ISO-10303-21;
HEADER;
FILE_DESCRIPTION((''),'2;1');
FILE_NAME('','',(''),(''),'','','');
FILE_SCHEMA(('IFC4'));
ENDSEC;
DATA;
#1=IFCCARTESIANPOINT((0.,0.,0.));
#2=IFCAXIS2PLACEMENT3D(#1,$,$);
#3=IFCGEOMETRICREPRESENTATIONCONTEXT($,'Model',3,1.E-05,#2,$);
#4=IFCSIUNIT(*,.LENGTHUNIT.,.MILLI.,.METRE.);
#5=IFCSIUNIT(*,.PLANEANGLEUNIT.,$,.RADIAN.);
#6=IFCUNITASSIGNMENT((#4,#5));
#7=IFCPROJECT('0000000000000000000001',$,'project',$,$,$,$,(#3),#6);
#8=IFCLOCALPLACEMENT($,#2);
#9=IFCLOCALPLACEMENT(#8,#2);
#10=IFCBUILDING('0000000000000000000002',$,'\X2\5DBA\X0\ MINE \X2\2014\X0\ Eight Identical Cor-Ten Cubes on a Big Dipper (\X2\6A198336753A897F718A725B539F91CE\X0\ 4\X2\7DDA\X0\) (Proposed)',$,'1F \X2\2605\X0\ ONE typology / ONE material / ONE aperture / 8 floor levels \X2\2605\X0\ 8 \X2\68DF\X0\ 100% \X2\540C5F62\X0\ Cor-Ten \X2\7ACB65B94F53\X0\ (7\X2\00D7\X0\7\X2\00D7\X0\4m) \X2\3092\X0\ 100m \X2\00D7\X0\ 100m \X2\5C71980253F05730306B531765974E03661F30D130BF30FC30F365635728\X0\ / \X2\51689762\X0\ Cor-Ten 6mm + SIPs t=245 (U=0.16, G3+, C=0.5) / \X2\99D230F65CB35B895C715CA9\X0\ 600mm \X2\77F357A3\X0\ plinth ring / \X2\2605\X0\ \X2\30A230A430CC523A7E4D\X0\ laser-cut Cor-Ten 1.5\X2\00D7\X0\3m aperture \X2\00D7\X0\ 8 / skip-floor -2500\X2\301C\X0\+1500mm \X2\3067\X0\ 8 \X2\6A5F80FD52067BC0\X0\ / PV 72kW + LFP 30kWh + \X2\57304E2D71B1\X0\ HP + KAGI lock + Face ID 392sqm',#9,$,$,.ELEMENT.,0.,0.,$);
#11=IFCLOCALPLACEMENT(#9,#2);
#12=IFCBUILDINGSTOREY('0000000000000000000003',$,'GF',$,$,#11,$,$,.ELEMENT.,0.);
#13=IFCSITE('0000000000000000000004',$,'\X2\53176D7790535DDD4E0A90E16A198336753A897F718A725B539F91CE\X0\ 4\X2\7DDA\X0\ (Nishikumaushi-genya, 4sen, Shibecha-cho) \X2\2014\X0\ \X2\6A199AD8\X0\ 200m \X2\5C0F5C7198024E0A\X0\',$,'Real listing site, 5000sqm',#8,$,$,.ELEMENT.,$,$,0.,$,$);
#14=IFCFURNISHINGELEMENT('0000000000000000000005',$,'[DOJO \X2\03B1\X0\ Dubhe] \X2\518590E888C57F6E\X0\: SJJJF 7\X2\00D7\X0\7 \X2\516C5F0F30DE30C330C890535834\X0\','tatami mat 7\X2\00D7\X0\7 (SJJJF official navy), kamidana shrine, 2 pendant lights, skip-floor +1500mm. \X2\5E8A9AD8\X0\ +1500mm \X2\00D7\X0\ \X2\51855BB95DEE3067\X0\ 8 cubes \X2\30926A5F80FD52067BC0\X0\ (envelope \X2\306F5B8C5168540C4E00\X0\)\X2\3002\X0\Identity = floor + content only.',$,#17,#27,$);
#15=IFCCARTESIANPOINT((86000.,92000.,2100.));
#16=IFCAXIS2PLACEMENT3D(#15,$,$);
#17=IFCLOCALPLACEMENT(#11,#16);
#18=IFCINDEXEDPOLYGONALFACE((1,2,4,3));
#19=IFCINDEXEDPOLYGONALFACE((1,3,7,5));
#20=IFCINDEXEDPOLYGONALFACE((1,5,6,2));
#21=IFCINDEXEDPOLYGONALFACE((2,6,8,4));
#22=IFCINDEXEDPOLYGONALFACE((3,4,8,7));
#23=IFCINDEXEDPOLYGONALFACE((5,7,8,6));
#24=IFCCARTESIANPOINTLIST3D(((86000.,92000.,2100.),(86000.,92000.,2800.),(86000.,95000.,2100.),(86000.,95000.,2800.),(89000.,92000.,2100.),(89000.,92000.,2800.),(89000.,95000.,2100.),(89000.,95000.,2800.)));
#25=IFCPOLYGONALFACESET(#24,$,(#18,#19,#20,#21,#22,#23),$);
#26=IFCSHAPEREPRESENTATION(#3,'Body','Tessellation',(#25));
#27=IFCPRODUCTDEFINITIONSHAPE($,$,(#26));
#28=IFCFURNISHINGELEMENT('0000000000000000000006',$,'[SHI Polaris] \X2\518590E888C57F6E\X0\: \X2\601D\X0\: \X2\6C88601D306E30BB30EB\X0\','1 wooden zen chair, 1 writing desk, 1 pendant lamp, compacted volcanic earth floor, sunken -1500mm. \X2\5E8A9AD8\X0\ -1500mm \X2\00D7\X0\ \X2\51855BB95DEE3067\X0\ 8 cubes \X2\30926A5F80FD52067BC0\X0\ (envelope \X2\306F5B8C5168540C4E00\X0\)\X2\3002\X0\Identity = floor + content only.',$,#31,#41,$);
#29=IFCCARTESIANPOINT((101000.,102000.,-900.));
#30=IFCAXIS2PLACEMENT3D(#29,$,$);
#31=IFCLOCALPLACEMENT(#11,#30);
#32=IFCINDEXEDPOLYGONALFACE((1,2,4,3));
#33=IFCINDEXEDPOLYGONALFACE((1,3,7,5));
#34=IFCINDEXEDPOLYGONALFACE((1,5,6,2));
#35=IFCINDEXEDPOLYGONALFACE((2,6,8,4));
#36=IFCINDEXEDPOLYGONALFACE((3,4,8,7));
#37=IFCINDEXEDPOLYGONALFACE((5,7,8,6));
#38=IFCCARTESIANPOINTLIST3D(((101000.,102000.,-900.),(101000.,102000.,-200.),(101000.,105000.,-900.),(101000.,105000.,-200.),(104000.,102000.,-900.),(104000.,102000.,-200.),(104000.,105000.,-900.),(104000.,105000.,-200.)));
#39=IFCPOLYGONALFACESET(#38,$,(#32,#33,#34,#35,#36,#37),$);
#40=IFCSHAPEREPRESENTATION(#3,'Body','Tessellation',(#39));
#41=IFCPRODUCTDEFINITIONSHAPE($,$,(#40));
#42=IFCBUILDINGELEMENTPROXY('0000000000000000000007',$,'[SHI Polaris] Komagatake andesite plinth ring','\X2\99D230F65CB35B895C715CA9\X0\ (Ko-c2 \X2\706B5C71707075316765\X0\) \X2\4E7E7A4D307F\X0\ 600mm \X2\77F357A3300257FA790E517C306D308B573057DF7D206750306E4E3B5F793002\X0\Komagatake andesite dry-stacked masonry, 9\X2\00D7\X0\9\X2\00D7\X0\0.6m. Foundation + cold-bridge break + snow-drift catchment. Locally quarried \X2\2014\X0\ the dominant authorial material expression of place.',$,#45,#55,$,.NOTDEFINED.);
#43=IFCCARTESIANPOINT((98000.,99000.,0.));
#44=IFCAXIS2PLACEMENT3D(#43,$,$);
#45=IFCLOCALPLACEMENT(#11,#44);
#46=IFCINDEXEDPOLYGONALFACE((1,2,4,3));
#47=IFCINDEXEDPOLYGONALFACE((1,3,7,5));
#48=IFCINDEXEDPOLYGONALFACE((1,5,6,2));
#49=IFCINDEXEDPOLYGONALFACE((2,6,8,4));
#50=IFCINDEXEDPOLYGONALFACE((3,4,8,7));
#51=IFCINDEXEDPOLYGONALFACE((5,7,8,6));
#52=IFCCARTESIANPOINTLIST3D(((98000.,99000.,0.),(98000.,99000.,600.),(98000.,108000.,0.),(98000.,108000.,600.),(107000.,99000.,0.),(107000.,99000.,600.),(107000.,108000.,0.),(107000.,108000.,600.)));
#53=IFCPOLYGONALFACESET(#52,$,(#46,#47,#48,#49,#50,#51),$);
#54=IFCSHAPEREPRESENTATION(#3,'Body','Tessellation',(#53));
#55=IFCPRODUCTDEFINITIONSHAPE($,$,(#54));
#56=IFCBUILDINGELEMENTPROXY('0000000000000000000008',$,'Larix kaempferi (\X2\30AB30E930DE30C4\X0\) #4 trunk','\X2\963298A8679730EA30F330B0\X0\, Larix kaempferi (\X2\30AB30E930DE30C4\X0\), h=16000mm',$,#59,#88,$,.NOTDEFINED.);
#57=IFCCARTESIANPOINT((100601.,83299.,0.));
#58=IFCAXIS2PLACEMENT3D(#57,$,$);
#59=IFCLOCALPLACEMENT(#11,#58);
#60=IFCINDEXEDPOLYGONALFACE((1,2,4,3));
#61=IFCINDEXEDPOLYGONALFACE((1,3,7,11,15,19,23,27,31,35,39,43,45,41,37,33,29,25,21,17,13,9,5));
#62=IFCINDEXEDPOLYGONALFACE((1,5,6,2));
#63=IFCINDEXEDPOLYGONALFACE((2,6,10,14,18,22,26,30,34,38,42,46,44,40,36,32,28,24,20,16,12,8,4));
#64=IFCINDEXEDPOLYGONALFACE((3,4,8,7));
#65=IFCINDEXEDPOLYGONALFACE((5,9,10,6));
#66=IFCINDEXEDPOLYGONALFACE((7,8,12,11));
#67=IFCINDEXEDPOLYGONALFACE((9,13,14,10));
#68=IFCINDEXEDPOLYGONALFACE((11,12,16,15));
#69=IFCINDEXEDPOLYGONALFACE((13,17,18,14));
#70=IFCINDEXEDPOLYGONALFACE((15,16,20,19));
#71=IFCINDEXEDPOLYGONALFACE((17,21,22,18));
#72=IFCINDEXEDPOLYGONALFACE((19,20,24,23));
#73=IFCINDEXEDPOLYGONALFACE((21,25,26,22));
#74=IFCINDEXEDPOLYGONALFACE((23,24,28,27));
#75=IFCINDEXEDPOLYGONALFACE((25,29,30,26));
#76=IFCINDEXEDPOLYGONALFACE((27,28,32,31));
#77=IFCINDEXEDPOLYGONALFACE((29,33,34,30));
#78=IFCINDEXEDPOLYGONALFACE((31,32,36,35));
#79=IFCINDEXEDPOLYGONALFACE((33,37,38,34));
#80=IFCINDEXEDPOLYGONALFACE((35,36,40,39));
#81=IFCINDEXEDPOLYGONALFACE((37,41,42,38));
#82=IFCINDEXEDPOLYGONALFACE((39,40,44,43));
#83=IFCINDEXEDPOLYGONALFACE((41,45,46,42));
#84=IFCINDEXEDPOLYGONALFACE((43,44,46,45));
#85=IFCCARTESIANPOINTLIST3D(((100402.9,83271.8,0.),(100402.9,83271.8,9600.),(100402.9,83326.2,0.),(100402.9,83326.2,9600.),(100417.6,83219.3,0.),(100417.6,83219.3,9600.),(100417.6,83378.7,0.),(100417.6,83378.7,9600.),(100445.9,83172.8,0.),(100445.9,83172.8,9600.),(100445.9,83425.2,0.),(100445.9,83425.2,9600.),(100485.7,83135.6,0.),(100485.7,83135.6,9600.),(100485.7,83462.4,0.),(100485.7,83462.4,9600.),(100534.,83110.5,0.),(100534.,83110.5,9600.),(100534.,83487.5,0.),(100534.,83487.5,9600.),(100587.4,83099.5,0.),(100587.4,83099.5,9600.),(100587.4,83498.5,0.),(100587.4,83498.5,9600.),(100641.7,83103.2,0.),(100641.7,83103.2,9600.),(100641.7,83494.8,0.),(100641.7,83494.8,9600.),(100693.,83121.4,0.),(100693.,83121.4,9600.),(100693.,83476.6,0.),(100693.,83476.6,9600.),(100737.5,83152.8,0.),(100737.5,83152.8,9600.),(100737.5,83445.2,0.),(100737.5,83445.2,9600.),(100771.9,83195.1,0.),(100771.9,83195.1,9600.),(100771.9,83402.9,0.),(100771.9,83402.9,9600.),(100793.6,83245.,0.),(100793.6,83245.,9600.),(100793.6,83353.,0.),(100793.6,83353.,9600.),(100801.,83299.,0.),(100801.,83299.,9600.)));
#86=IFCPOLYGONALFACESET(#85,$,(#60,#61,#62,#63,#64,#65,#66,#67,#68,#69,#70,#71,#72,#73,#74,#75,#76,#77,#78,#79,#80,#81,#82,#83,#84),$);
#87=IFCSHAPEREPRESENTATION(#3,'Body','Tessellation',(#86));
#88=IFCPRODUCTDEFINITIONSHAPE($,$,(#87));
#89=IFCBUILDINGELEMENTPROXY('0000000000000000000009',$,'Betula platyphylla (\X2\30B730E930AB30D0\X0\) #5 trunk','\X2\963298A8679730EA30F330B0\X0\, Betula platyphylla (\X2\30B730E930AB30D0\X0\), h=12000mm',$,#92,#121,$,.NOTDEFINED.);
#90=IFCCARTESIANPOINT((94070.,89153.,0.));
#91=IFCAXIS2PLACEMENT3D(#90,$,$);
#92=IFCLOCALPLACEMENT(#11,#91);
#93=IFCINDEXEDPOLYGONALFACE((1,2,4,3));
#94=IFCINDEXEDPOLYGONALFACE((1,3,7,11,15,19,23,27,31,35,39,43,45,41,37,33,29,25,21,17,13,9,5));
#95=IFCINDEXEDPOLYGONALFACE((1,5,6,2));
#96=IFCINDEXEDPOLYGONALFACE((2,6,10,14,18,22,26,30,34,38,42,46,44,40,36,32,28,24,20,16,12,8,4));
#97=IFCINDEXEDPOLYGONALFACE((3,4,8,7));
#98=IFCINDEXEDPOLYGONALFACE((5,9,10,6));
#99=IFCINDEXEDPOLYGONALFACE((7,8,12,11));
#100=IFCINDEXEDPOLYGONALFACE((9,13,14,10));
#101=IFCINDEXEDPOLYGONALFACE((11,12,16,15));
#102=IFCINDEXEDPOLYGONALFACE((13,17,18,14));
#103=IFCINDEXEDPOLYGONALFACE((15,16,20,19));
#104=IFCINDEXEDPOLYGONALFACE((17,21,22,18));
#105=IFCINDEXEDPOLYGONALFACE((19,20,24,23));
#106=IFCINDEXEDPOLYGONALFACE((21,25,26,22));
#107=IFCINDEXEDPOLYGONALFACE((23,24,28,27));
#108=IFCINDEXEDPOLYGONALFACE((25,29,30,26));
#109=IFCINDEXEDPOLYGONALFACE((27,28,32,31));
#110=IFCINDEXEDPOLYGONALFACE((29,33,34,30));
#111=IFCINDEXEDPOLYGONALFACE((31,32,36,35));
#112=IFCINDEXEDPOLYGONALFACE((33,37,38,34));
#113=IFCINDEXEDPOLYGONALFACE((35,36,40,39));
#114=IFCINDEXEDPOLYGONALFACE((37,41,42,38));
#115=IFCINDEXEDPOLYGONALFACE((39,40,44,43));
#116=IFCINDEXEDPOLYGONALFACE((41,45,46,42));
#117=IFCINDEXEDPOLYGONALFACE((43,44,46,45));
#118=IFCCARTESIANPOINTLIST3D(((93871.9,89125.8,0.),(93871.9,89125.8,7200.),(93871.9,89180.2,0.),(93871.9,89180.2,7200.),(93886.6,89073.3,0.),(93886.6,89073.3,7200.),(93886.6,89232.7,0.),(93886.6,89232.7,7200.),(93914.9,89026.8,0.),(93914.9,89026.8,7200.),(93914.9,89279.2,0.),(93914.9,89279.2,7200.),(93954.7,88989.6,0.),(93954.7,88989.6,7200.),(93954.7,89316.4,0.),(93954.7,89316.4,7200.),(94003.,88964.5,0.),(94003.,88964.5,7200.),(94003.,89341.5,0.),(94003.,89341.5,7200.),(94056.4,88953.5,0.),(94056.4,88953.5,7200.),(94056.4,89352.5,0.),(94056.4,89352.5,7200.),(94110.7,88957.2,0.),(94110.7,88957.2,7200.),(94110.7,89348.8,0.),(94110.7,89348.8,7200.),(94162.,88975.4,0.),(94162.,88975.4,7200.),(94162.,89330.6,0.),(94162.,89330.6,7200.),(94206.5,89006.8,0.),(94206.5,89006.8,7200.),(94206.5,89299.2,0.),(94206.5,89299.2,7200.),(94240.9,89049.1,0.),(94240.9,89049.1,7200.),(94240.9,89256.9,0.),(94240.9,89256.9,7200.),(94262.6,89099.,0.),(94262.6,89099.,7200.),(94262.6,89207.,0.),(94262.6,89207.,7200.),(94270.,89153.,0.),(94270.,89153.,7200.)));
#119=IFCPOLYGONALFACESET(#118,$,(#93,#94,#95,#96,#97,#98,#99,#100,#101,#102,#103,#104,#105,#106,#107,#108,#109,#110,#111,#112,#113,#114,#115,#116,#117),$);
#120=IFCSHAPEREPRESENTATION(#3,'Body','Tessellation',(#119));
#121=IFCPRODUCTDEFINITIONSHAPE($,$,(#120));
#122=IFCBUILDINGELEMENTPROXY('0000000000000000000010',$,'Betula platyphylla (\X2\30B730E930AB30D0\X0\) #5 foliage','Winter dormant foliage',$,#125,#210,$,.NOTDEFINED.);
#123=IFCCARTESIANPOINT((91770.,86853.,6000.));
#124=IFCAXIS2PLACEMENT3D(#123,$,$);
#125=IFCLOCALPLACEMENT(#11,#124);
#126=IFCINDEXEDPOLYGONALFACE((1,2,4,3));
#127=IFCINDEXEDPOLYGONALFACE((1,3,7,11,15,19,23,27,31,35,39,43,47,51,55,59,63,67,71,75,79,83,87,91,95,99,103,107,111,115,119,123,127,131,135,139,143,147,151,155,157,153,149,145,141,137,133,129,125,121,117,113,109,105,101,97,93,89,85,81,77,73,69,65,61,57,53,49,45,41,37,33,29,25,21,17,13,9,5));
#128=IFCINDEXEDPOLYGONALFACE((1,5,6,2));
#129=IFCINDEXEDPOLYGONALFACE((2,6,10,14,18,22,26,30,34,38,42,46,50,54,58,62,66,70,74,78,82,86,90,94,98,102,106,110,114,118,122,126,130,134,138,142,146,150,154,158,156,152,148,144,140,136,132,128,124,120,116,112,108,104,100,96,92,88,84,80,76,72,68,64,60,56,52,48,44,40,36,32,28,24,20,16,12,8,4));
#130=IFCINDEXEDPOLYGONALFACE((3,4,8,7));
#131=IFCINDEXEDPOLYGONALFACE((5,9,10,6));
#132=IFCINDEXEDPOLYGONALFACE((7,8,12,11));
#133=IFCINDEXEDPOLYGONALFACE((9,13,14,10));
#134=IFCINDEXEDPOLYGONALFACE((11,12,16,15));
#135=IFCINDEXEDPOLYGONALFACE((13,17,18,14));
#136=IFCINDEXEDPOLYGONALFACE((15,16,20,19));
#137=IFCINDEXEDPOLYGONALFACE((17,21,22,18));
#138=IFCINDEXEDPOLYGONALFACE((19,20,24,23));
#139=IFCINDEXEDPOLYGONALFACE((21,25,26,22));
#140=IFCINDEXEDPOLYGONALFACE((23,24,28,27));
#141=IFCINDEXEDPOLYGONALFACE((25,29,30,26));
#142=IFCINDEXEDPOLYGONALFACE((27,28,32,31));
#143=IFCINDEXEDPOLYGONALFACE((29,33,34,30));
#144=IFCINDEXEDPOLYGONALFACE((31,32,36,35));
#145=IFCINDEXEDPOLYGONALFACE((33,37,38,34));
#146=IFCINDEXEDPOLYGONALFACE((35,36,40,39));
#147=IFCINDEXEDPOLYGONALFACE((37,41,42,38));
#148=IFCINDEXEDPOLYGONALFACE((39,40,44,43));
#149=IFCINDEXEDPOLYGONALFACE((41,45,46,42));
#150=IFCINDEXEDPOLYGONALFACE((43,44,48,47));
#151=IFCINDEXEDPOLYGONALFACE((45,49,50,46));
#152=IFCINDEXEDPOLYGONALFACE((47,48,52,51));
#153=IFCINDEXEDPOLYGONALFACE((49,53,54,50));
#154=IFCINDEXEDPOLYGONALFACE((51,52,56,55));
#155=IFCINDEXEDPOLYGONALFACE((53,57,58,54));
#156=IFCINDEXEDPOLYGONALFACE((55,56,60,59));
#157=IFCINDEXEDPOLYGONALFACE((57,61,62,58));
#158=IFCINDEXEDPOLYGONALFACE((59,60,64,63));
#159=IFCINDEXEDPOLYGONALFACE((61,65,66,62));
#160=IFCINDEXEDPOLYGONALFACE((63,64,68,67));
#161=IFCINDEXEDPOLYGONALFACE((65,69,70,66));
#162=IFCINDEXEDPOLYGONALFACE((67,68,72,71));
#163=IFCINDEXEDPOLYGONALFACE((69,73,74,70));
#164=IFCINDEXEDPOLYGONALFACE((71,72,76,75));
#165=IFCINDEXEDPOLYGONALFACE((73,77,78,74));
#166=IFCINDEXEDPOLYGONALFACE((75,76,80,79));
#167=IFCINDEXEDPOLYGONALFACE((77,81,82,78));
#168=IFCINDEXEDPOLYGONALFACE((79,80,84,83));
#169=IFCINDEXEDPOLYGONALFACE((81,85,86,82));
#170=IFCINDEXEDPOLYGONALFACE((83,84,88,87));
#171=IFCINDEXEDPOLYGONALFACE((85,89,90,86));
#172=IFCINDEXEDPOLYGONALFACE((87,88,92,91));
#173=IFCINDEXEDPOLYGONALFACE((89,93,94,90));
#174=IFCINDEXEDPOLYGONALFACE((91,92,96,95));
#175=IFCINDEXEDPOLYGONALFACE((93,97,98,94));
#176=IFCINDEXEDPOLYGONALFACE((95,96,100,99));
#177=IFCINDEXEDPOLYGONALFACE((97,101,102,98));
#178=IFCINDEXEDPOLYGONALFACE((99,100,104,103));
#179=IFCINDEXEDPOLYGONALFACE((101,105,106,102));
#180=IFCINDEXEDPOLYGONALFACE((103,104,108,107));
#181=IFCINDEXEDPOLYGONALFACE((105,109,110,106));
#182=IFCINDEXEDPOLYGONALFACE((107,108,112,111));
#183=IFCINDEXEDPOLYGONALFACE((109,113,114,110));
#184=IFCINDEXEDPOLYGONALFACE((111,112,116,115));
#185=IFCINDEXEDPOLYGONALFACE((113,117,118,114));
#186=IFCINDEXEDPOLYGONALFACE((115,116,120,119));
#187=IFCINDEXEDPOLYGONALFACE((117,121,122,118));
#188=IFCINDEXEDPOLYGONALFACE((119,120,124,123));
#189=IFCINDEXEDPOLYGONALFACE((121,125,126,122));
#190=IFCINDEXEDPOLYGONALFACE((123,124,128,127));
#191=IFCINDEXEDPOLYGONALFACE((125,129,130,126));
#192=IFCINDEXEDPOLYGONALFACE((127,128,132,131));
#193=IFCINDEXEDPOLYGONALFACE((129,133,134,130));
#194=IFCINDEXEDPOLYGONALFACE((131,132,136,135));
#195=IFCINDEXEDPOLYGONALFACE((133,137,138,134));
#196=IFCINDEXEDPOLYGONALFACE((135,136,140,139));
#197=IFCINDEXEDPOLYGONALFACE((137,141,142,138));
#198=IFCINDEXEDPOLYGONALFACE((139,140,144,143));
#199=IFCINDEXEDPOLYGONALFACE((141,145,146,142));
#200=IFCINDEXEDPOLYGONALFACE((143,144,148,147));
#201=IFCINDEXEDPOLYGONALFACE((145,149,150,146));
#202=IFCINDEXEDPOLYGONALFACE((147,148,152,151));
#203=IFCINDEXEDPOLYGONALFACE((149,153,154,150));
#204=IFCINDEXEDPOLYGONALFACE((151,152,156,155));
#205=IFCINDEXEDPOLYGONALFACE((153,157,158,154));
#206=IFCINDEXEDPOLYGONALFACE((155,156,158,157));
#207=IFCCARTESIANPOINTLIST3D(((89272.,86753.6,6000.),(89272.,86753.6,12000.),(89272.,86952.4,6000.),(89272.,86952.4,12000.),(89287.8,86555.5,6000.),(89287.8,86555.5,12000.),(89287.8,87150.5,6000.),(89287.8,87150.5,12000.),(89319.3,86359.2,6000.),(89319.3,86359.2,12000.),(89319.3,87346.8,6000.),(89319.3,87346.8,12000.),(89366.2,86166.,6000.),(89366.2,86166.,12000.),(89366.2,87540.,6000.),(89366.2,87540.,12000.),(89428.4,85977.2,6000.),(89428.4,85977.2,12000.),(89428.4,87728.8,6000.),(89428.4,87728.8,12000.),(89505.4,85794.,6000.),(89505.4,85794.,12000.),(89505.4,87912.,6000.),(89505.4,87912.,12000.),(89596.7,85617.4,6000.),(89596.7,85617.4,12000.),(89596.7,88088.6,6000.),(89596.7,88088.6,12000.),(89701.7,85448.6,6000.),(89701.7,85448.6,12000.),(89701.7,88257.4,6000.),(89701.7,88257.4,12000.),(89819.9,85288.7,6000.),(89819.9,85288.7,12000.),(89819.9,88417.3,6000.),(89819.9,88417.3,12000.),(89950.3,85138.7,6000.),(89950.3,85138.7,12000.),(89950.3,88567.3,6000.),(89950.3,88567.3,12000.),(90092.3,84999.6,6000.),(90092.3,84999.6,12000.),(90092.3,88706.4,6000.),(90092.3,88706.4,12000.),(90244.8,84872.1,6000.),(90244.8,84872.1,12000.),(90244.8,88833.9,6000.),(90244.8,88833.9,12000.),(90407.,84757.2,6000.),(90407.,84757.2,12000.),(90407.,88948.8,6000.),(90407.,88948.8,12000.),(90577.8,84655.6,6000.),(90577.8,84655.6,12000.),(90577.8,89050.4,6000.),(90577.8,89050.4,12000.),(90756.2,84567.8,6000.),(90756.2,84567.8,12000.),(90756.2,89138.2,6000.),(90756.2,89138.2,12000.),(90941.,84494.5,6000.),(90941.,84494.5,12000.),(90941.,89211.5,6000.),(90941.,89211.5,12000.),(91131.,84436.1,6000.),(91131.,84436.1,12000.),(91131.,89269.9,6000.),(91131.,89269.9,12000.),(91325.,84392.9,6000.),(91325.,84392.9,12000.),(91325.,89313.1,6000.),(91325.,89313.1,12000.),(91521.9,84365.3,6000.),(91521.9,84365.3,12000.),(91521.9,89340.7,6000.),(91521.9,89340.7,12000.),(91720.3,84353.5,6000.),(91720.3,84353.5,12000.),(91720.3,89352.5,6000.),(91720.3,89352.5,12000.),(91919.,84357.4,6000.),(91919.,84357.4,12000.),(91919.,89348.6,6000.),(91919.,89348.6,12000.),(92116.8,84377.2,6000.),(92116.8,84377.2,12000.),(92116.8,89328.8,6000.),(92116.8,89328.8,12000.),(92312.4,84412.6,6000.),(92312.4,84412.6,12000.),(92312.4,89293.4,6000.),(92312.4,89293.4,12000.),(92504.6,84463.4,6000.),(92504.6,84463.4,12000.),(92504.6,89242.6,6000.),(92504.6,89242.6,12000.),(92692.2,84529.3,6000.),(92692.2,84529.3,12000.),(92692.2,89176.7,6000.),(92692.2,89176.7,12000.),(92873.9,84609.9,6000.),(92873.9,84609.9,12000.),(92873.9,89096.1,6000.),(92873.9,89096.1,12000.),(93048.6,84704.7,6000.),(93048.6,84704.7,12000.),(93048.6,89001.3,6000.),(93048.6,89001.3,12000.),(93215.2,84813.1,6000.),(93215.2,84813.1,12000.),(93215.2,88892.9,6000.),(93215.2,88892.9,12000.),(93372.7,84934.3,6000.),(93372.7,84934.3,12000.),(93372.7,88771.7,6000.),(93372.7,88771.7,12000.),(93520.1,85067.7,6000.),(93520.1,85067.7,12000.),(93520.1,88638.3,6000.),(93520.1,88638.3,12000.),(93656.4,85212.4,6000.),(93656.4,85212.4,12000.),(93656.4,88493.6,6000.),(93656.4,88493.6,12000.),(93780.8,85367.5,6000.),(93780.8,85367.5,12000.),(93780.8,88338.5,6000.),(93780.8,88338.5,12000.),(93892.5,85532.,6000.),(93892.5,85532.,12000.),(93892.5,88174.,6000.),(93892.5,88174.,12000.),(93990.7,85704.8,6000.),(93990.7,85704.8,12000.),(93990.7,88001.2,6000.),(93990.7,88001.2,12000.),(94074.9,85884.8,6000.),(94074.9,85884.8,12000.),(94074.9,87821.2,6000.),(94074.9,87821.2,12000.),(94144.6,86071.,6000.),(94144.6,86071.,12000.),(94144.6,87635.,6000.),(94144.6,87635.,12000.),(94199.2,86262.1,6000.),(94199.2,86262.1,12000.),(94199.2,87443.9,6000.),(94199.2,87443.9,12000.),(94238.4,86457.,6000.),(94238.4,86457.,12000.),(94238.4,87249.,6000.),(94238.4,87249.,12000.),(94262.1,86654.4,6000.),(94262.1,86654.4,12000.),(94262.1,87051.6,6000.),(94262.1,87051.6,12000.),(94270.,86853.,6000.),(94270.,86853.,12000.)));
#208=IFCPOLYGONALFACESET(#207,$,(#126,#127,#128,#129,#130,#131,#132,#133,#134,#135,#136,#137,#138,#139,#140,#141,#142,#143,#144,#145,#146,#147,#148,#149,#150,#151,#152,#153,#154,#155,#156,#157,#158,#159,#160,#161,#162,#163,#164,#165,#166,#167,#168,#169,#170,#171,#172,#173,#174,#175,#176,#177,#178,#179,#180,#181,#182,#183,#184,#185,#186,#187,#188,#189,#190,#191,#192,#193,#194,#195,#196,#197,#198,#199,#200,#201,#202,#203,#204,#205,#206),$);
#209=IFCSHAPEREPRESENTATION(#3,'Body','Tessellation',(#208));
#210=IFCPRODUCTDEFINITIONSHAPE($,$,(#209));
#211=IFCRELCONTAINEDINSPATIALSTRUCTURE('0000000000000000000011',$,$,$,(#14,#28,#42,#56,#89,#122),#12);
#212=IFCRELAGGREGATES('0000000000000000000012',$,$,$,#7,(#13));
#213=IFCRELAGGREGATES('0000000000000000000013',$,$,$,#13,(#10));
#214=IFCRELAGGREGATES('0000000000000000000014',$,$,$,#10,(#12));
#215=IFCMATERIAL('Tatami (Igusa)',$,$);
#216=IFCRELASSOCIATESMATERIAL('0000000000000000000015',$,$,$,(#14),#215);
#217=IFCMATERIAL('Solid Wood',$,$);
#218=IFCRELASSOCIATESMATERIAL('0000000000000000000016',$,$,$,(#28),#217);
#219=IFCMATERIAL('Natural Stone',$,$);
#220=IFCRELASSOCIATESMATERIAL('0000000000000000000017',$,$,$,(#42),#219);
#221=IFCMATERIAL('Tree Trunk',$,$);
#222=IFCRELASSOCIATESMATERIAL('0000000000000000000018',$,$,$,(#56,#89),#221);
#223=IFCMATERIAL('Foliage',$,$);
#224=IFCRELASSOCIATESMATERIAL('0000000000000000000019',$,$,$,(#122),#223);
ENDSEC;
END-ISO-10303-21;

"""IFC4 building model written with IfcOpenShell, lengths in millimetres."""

from ifc_helpers import new_model, si_unit, frame, frame_2d, origin, origin_2d, place, context, project, spatial, rectangle, circle, extrude, material, element, save


model = new_model("IFC4")

# Units and contexts
model_context = context("Model", 3, precision=1e-05, world=origin())
ifc_project = project(units=[si_unit("LENGTHUNIT", "METRE", prefix="MILLI"), si_unit("PLANEANGLEUNIT", "RADIAN")], contexts=[model_context])

# Site, building, storey
site_placement = place(None, origin())
site = spatial("IfcSite", under=ifc_project, at=site_placement, Name="北海道川上郡標茶町西熊牛原野 4線 (Nishikumaushi-genya, 4sen, Shibecha-cho) — 標高 200m 小山頂上", ObjectType="Real listing site, 5000sqm", CompositionType="ELEMENT", RefElevation=0.0)
building_placement = place(site_placement, origin())
building = spatial("IfcBuilding", under=site, at=building_placement, Name="嶺 MINE — Eight Identical Cor-Ten Cubes on a Big Dipper (標茶町西熊牛原野 4線) (Proposed)", ObjectType="1F ★ ONE typology / ONE material / ONE aperture / 8 floor levels ★ 8 棟 100% 同形 Cor-Ten 立方体 (7×7×4m) を 100m × 100m 山頂台地に北斗七星パターン散在 / 全面 Cor-Ten 6mm + SIPs t=245 (U=0.16, G3+, C=0.5) / 駒ヶ岳安山岩 600mm 石垣 plinth ring / ★ アイヌ刺繍 laser-cut Cor-Ten 1.5×3m aperture × 8 / skip-floor -2500〜+1500mm で 8 機能分節 / PV 72kW + LFP 30kWh + 地中熱 HP + KAGI lock + Face ID 392sqm", CompositionType="ELEMENT", ElevationOfRefHeight=0.0, ElevationOfTerrain=0.0)
storey_placement = place(building_placement, origin())
storey = spatial("IfcBuildingStorey", under=building, at=storey_placement, Name="GF", CompositionType="ELEMENT", Elevation=0.0)

# Furnishing elements
ifc_material_1 = material(Name="Tatami (Igusa)")
furnishing_1_placement = place(storey_placement, frame((86000.0, 92000.0, 2100.0)))
element("IfcFurnishingElement", 1, at=furnishing_1_placement, inside=storey, material=ifc_material_1, Name="[DOJO α Dubhe] 内部装置: SJJJF 7×7 公式マット道場", Description="tatami mat 7×7 (SJJJF official navy), kamidana shrine, 2 pendant lights, skip-floor +1500mm. 床高 +1500mm × 内容差で 8 cubes を機能分節 (envelope は完全同一)。Identity = floor + content only.", context=model_context, shape_type="SweptSolid", body=[
    extrude(rectangle(XDim=3000.0, YDim=3000.0, at=frame_2d((1500.0, 1500.0))), frame((86000.0, 92000.0, 2100.0)), (0.0, 0.0, 1.0), 700.0),
])
ifc_material_2 = material(Name="Solid Wood")
furnishing_2_placement = place(storey_placement, frame((101000.0, 102000.0, -900.0)))
element("IfcFurnishingElement", 2, at=furnishing_2_placement, inside=storey, material=ifc_material_2, Name="[SHI Polaris] 内部装置: 思: 沈思のセル", Description="1 wooden zen chair, 1 writing desk, 1 pendant lamp, compacted volcanic earth floor, sunken -1500mm. 床高 -1500mm × 内容差で 8 cubes を機能分節 (envelope は完全同一)。Identity = floor + content only.", context=model_context, shape_type="SweptSolid", body=[
    extrude(rectangle(XDim=3000.0, YDim=3000.0, at=frame_2d((1500.0, 1500.0))), frame((101000.0, 102000.0, -900.0)), (0.0, 0.0, 1.0), 700.0),
])

# Building element proxies
ifc_material_3 = material(Name="Natural Stone")
proxy_1_placement = place(storey_placement, frame((98000.0, 99000.0, 0.0)))
element("IfcBuildingElementProxy", 3, at=proxy_1_placement, inside=storey, material=ifc_material_3, Name="[SHI Polaris] Komagatake andesite plinth ring", Description="駒ヶ岳安山岩 (Ko-c2 火山灰由来) 乾積み 600mm 石垣。基礎兼ねる地域素材の主役。Komagatake andesite dry-stacked masonry, 9×9×0.6m. Foundation + cold-bridge break + snow-drift catchment. Locally quarried — the dominant authorial material expression of place.", PredefinedType="NOTDEFINED", context=model_context, shape_type="SweptSolid", body=[
    extrude(rectangle(XDim=9000.0, YDim=9000.0, at=frame_2d((4500.0, 4500.0))), frame((98000.0, 99000.0, 0.0)), (0.0, 0.0, 1.0), 600.0),
])
ifc_material_4 = material(Name="Tree Trunk")
proxy_2_placement = place(storey_placement, frame((100601.0, 83299.0, 0.0)))
element("IfcBuildingElementProxy", 4, at=proxy_2_placement, inside=storey, material=ifc_material_4, Name="Larix kaempferi (カラマツ) #4 trunk", Description="防風林リング, Larix kaempferi (カラマツ), h=16000mm", PredefinedType="NOTDEFINED", context=model_context, shape_type="SweptSolid", body=[
    extrude(circle(Radius=200.0, at=origin_2d()), frame((100601.0, 83299.0, 0.0)), (0.0, 0.0, 1.0), 9600.0),
])
proxy_3_placement = place(storey_placement, frame((94070.0, 89153.0, 0.0)))
element("IfcBuildingElementProxy", 5, at=proxy_3_placement, inside=storey, material=ifc_material_4, Name="Betula platyphylla (シラカバ) #5 trunk", Description="防風林リング, Betula platyphylla (シラカバ), h=12000mm", PredefinedType="NOTDEFINED", context=model_context, shape_type="SweptSolid", body=[
    extrude(circle(Radius=200.0, at=origin_2d()), frame((94070.0, 89153.0, 0.0)), (0.0, 0.0, 1.0), 7200.0),
])
ifc_material_5 = material(Name="Foliage")
proxy_4_placement = place(storey_placement, frame((91770.0, 86853.0, 6000.0)))
element("IfcBuildingElementProxy", 6, at=proxy_4_placement, inside=storey, material=ifc_material_5, Name="Betula platyphylla (シラカバ) #5 foliage", Description="Winter dormant foliage", PredefinedType="NOTDEFINED", context=model_context, shape_type="SweptSolid", body=[
    extrude(circle(Radius=2500.0, at=origin_2d()), frame((91770.0, 86853.0, 6000.0)), (0.0, 0.0, 1.0), 6000.0),
])

save(model, "model.ifc")
